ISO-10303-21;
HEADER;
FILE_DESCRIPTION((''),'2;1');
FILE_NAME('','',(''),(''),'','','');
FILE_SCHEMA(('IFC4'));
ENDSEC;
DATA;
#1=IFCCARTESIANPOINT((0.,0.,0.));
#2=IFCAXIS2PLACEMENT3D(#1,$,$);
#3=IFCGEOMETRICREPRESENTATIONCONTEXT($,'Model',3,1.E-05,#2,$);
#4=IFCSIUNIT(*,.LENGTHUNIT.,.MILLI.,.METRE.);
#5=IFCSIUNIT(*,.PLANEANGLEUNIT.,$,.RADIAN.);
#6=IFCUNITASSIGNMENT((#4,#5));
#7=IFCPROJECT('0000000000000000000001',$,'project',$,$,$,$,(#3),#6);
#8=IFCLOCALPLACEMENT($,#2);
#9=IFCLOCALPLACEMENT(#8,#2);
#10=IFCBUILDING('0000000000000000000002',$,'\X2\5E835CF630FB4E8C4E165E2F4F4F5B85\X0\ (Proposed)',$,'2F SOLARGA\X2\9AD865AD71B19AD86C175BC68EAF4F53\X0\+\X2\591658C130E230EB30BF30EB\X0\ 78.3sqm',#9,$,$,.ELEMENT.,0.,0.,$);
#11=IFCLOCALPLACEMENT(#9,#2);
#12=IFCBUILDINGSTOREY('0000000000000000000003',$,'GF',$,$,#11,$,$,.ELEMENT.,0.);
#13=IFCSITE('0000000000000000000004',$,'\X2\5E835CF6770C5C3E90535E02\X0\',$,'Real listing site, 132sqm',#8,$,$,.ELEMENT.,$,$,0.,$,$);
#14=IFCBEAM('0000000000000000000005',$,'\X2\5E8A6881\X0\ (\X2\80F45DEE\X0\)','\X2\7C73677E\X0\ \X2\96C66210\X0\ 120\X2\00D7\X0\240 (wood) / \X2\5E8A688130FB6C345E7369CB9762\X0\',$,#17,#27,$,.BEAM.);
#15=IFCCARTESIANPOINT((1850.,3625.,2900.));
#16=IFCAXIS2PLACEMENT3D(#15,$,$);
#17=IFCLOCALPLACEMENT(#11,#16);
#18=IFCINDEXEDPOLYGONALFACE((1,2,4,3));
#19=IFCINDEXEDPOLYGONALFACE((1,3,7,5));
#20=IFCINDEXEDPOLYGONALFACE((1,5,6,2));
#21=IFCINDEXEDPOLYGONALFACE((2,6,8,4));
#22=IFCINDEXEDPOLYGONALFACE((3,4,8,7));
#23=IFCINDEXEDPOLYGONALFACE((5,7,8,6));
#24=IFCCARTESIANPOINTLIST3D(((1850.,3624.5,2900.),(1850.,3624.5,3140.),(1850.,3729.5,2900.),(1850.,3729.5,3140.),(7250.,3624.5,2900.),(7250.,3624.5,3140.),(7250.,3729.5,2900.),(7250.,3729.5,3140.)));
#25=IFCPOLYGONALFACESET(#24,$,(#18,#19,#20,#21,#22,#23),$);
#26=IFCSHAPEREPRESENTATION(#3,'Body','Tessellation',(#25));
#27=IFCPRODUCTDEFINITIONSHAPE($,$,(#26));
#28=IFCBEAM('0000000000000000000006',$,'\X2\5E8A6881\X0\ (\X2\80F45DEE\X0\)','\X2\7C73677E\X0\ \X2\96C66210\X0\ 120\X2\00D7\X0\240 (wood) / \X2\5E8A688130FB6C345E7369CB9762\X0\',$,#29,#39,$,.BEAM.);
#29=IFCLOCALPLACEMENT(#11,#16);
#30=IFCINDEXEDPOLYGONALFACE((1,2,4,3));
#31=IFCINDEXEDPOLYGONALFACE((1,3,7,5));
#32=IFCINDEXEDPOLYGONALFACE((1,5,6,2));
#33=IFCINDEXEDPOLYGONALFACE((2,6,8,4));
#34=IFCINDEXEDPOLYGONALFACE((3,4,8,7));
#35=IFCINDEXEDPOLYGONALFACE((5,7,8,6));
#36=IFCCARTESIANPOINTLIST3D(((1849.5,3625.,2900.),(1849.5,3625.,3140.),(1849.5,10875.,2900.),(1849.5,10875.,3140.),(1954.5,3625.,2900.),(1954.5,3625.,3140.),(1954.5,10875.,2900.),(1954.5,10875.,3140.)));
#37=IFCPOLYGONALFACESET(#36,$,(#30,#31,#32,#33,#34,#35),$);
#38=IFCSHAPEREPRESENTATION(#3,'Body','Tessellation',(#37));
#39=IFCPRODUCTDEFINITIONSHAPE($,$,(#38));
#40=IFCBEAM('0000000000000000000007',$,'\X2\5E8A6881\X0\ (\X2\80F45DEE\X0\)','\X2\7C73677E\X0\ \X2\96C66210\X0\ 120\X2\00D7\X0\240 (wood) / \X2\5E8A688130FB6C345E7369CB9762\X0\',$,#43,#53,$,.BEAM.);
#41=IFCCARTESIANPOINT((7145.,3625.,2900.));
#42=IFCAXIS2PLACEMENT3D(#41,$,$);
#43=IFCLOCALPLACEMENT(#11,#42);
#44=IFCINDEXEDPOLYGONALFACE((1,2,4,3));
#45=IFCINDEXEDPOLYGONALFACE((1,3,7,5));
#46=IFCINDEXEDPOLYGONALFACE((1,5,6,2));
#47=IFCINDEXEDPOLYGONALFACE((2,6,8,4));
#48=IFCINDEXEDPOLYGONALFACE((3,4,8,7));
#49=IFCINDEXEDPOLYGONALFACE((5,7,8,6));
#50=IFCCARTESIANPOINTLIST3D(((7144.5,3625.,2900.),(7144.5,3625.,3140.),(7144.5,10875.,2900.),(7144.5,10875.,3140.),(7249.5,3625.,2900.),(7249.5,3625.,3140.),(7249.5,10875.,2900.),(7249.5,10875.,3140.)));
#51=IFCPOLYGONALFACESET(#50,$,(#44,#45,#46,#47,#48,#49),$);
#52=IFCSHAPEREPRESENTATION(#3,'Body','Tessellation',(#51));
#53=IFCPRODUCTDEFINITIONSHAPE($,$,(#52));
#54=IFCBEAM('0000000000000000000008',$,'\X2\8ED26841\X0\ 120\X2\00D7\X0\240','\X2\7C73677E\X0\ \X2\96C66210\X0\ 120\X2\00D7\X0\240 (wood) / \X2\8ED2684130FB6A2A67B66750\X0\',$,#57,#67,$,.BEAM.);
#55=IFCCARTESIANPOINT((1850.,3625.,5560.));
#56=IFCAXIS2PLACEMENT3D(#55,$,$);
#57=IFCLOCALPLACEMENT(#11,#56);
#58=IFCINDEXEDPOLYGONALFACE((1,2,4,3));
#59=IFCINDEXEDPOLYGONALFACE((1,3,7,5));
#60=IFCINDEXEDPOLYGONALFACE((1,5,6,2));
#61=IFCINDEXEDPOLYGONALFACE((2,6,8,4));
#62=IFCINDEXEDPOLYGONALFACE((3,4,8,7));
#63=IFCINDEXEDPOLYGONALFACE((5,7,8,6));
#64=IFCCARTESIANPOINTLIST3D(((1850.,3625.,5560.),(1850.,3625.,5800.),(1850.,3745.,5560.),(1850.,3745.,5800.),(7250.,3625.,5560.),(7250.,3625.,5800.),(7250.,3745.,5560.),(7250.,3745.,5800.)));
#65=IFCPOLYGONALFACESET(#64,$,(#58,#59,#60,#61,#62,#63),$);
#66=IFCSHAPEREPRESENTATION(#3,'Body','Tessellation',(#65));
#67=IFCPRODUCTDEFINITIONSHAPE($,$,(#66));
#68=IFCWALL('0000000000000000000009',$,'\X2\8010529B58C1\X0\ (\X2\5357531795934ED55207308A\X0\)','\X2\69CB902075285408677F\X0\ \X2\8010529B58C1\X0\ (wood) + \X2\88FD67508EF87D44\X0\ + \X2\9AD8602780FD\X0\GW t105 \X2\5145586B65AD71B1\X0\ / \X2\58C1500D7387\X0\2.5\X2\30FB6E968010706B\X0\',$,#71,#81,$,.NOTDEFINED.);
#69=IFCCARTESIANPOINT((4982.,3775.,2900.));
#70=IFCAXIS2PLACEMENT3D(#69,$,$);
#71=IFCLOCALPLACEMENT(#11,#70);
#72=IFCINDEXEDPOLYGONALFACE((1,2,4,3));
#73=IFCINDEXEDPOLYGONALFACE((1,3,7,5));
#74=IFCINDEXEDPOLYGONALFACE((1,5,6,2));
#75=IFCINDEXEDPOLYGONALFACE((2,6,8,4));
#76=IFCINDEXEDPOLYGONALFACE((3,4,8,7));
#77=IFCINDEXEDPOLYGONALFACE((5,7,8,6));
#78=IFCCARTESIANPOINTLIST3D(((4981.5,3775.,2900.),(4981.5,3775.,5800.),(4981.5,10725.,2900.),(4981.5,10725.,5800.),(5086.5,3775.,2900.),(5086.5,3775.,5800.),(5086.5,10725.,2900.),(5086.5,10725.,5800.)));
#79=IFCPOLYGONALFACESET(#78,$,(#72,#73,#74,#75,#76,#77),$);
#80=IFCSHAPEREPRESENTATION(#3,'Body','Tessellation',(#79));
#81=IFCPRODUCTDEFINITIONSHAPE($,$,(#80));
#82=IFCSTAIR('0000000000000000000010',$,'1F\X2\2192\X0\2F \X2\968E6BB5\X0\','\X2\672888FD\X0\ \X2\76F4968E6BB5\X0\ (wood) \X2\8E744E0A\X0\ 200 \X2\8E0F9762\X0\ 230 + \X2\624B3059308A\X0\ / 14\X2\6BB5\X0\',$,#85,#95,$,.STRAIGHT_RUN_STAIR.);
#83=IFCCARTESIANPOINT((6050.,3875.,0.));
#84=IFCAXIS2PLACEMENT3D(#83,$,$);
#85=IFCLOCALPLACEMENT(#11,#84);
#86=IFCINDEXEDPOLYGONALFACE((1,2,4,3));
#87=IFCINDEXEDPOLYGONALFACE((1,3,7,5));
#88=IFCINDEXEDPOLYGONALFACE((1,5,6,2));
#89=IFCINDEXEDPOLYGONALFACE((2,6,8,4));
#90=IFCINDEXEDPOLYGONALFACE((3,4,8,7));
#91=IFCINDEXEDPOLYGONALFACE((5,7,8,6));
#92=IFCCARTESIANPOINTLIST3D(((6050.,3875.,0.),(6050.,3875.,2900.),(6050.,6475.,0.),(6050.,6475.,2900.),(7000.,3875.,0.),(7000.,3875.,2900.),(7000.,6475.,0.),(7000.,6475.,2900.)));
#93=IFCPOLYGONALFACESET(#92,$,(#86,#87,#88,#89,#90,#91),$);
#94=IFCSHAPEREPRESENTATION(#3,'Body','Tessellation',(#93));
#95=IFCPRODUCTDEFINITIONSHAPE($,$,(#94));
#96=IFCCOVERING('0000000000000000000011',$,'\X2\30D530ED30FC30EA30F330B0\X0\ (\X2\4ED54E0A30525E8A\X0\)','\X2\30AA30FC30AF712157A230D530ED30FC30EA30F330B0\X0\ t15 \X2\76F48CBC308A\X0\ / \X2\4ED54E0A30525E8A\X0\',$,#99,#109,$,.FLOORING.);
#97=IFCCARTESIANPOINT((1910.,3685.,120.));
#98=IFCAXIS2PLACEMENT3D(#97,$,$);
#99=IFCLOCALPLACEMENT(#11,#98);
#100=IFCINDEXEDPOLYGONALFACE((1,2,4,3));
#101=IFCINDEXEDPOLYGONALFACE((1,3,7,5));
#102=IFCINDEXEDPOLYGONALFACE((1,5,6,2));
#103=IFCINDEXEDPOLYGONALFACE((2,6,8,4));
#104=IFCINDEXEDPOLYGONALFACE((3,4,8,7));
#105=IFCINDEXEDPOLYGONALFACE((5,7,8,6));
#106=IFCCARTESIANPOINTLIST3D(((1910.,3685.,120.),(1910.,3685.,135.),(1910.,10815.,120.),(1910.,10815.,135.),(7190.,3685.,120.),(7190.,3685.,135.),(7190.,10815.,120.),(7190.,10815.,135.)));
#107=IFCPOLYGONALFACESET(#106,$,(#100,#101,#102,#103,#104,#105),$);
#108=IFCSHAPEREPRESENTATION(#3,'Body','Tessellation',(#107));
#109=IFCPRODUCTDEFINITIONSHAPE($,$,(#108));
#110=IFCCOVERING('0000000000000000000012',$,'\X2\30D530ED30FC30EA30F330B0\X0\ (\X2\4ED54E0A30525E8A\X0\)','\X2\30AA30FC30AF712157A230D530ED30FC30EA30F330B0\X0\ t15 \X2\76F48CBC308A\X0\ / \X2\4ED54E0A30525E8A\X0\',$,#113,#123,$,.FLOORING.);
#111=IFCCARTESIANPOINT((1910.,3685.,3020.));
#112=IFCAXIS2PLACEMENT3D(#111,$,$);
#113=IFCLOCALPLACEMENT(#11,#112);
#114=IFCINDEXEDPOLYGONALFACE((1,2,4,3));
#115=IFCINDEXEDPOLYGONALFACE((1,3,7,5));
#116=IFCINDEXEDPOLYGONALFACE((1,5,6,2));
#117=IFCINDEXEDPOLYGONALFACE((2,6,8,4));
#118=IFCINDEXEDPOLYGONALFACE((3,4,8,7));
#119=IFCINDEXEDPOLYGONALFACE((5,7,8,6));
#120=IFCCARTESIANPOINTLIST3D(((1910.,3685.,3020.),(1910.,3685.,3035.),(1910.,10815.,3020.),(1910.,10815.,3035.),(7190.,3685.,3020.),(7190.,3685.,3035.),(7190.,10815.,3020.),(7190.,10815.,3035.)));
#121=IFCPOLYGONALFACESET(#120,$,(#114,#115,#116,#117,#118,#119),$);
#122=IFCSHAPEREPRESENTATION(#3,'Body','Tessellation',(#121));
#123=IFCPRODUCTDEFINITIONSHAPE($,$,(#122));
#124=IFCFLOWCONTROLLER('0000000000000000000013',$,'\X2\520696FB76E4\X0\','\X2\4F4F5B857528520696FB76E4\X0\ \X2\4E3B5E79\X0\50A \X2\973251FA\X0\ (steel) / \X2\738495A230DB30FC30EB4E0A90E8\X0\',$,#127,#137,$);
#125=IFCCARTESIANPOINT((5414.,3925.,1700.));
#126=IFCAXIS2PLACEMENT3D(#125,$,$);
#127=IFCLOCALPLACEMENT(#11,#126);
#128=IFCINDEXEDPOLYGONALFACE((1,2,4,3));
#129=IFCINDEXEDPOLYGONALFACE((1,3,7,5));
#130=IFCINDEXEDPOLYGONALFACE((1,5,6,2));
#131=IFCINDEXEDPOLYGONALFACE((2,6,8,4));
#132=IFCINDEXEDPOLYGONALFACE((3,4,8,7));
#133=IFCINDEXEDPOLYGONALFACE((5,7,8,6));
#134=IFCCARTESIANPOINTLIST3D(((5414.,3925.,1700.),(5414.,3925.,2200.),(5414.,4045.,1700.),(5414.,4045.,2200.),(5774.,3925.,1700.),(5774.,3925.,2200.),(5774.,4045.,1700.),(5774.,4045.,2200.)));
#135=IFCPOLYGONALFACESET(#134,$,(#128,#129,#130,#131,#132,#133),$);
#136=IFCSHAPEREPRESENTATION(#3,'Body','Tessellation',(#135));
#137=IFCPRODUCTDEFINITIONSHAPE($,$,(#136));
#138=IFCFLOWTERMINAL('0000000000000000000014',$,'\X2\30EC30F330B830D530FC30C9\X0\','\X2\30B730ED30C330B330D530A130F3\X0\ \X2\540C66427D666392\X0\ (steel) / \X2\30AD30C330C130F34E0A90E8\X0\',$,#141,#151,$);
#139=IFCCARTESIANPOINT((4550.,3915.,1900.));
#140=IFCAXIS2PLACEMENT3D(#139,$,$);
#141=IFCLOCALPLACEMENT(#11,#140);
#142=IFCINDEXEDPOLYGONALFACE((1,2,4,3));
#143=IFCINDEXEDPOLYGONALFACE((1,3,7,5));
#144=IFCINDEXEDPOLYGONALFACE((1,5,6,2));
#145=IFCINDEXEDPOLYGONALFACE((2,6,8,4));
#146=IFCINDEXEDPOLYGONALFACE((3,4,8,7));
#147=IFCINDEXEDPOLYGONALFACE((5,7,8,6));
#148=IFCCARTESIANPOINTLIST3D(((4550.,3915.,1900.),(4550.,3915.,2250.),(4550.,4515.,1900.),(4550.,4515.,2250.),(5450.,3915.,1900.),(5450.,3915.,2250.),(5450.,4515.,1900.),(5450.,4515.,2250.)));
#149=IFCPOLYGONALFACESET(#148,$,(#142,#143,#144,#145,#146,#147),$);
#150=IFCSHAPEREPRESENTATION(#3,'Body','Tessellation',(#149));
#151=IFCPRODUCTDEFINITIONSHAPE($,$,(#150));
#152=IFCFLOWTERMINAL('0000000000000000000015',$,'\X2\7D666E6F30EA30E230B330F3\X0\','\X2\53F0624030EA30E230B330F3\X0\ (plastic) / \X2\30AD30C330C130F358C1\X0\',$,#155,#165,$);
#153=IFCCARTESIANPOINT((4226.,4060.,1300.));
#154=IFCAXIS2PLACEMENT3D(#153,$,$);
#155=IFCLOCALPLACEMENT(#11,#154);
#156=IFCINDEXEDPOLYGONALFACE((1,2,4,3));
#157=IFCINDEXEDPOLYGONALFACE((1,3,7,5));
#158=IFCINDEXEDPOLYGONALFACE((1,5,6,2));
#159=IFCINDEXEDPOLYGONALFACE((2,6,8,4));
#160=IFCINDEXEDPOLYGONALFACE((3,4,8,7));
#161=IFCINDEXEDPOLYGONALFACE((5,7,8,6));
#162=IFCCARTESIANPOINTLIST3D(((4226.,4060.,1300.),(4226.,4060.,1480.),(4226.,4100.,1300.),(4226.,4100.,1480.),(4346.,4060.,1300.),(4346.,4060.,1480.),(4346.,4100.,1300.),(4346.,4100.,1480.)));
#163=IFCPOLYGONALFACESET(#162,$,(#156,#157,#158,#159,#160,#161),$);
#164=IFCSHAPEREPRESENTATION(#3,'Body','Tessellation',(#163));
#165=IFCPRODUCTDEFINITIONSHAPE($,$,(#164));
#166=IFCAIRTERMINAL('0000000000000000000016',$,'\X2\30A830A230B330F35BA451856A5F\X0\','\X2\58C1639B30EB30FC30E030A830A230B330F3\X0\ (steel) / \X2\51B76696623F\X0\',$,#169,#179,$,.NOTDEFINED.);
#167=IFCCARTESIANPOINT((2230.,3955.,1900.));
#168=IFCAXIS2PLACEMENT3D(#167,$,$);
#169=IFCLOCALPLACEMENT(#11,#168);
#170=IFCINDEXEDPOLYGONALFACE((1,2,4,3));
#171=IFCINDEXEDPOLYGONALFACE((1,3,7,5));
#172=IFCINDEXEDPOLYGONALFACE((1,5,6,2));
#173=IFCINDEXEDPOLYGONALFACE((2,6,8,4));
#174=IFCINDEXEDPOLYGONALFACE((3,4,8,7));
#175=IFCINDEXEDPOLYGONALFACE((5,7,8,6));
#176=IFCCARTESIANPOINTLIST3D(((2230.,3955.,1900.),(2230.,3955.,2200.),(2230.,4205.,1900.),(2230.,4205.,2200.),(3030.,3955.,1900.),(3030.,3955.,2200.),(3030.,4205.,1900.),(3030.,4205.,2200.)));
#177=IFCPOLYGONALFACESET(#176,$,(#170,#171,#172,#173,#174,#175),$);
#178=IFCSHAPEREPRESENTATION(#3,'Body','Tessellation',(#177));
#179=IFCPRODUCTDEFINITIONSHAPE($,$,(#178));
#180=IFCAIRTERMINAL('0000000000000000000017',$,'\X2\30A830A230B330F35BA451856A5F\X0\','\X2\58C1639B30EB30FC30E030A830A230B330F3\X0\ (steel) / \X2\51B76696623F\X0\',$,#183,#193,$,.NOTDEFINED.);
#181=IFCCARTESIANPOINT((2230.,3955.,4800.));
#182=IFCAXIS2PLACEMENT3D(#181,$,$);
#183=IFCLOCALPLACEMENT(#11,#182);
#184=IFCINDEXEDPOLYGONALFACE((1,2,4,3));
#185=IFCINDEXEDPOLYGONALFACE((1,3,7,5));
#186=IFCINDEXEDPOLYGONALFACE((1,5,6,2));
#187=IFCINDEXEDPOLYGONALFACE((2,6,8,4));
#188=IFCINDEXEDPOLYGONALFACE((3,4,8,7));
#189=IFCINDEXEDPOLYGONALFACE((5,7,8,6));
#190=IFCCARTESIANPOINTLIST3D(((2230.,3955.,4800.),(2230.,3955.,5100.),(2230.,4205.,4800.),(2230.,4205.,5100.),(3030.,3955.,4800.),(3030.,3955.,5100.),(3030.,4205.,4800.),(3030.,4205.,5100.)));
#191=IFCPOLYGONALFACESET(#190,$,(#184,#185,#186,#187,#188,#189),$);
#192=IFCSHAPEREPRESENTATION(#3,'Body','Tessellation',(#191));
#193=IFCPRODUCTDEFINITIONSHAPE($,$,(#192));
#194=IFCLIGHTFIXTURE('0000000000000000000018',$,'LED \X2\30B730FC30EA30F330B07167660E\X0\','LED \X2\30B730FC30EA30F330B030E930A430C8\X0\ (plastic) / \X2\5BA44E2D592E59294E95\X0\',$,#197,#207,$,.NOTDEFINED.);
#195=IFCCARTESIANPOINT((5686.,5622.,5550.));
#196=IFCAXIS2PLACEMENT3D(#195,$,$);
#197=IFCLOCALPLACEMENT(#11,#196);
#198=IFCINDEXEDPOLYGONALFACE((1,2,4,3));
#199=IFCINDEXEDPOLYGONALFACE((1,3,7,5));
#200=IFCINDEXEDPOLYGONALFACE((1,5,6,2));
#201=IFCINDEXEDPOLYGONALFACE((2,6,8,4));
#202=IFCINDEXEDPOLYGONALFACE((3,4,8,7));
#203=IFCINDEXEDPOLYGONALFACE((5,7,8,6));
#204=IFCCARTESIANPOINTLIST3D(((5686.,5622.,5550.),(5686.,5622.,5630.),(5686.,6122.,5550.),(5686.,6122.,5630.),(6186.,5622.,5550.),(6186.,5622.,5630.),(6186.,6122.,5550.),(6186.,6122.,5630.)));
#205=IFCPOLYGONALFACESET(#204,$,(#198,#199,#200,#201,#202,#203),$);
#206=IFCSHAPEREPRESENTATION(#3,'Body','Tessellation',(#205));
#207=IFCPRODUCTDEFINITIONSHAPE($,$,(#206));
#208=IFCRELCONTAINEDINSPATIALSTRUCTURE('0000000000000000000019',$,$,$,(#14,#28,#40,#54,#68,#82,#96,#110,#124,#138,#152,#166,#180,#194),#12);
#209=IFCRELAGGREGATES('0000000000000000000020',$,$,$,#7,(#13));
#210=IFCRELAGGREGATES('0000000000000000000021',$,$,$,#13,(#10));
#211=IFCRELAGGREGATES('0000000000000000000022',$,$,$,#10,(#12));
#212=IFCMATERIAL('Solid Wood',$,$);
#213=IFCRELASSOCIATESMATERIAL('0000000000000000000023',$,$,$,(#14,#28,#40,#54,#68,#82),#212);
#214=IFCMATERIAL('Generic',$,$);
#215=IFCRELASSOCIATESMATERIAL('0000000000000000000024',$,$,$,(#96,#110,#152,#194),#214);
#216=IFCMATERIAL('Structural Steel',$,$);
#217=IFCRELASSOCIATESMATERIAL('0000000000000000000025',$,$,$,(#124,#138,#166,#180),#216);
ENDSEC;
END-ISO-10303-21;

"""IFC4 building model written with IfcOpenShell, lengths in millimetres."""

from ifc_helpers import new_model, si_unit, frame, frame_2d, origin, place, context, project, spatial, rectangle, extrude, material, element, save


model = new_model("IFC4")

# Units and contexts
model_context = context("Model", 3, precision=1e-05, world=origin())
ifc_project = project(units=[si_unit("LENGTHUNIT", "METRE", prefix="MILLI"), si_unit("PLANEANGLEUNIT", "RADIAN")], contexts=[model_context])

# Site, building, storey
site_placement = place(None, origin())
site = spatial("IfcSite", under=ifc_project, at=site_placement, Name="広島県尾道市", ObjectType="Real listing site, 132sqm", CompositionType="ELEMENT", RefElevation=0.0)
building_placement = place(site_placement, origin())
building = spatial("IfcBuilding", under=site, at=building_placement, Name="広島・二世帯住宅 (Proposed)", ObjectType="2F SOLARGA高断熱高気密躯体+外壁モルタル 78.3sqm", CompositionType="ELEMENT", ElevationOfRefHeight=0.0, ElevationOfTerrain=0.0)
storey_placement = place(building_placement, origin())
storey = spatial("IfcBuildingStorey", under=building, at=storey_placement, Name="GF", CompositionType="ELEMENT", Elevation=0.0)

# Shared definitions
ifc_material_1 = material(Name="Solid Wood")

# Beams
beam_1_placement = place(storey_placement, frame((1850.0, 3625.0, 2900.0)))
element("IfcBeam", 1, at=beam_1_placement, inside=storey, material=ifc_material_1, Name="床梁 (胴差)", Description="米松 集成 120×240 (wood) / 床梁・水平構面", PredefinedType="BEAM", context=model_context, shape_type="SweptSolid", body=[
    extrude(rectangle(XDim=5400.0, YDim=105.0, at=frame_2d((2700.0, 52.0))), frame((1850.0, 3625.0, 2900.0)), (0.0, 0.0, 1.0), 240.0),
])
beam_2_placement = place(storey_placement, frame((1850.0, 3625.0, 2900.0)))
element("IfcBeam", 2, at=beam_2_placement, inside=storey, material=ifc_material_1, Name="床梁 (胴差)", Description="米松 集成 120×240 (wood) / 床梁・水平構面", PredefinedType="BEAM", context=model_context, shape_type="SweptSolid", body=[
    extrude(rectangle(XDim=105.0, YDim=7250.0, at=frame_2d((52.0, 3625.0))), frame((1850.0, 3625.0, 2900.0)), (0.0, 0.0, 1.0), 240.0),
])
beam_3_placement = place(storey_placement, frame((7145.0, 3625.0, 2900.0)))
element("IfcBeam", 3, at=beam_3_placement, inside=storey, material=ifc_material_1, Name="床梁 (胴差)", Description="米松 集成 120×240 (wood) / 床梁・水平構面", PredefinedType="BEAM", context=model_context, shape_type="SweptSolid", body=[
    extrude(rectangle(XDim=105.0, YDim=7250.0, at=frame_2d((52.0, 3625.0))), frame((7145.0, 3625.0, 2900.0)), (0.0, 0.0, 1.0), 240.0),
])
beam_4_placement = place(storey_placement, frame((1850.0, 3625.0, 5560.0)))
element("IfcBeam", 4, at=beam_4_placement, inside=storey, material=ifc_material_1, Name="軒桁 120×240", Description="米松 集成 120×240 (wood) / 軒桁・横架材", PredefinedType="BEAM", context=model_context, shape_type="SweptSolid", body=[
    extrude(rectangle(XDim=5400.0, YDim=120.0, at=frame_2d((2700.0, 60.0))), frame((1850.0, 3625.0, 5560.0)), (0.0, 0.0, 1.0), 240.0),
])

# Wall
wall_1_placement = place(storey_placement, frame((4982.0, 3775.0, 2900.0)))
element("IfcWall", 5, at=wall_1_placement, inside=storey, material=ifc_material_1, Name="耐力壁 (南北間仕切り)", Description="構造用合板 耐力壁 (wood) + 製材軸組 + 高性能GW t105 充填断熱 / 壁倍率2.5・準耐火", PredefinedType="NOTDEFINED", context=model_context, shape_type="SweptSolid", body=[
    extrude(rectangle(XDim=105.0, YDim=6950.0, at=frame_2d((52.0, 3475.0))), frame((4982.0, 3775.0, 2900.0)), (0.0, 0.0, 1.0), 2900.0),
])

# Stair
stair_placement = place(storey_placement, frame((6050.0, 3875.0, 0.0)))
element("IfcStair", 6, at=stair_placement, inside=storey, material=ifc_material_1, Name="1F→2F 階段", Description="木製 直階段 (wood) 蹴上 200 踏面 230 + 手すり / 14段", PredefinedType="STRAIGHT_RUN_STAIR", context=model_context, shape_type="SweptSolid", body=[
    extrude(rectangle(XDim=950.0, YDim=2600.0, at=frame_2d((475.0, 1300.0))), frame((6050.0, 3875.0, 0.0)), (0.0, 0.0, 1.0), 2900.0),
])

# Coverings
ifc_material_2 = material(Name="Generic")
covering_1_placement = place(storey_placement, frame((1910.0, 3685.0, 120.0)))
element("IfcCovering", 7, at=covering_1_placement, inside=storey, material=ifc_material_2, Name="フローリング (仕上げ床)", Description="オーク無垢フローリング t15 直貼り / 仕上げ床", PredefinedType="FLOORING", context=model_context, shape_type="SweptSolid", body=[
    extrude(rectangle(XDim=5280.0, YDim=7130.0, at=frame_2d((2640.0, 3565.0))), frame((1910.0, 3685.0, 120.0)), (0.0, 0.0, 1.0), 15.0),
])
covering_2_placement = place(storey_placement, frame((1910.0, 3685.0, 3020.0)))
element("IfcCovering", 8, at=covering_2_placement, inside=storey, material=ifc_material_2, Name="フローリング (仕上げ床)", Description="オーク無垢フローリング t15 直貼り / 仕上げ床", PredefinedType="FLOORING", context=model_context, shape_type="SweptSolid", body=[
    extrude(rectangle(XDim=5280.0, YDim=7130.0, at=frame_2d((2640.0, 3565.0))), frame((1910.0, 3685.0, 3020.0)), (0.0, 0.0, 1.0), 15.0),
])

# Flow controller
ifc_material_3 = material(Name="Structural Steel")
flow_controller_placement = place(storey_placement, frame((5414.0, 3925.0, 1700.0)))
element("IfcFlowController", 9, at=flow_controller_placement, inside=storey, material=ifc_material_3, Name="分電盤", Description="住宅用分電盤 主幹50A 露出 (steel) / 玄関ホール上部", context=model_context, shape_type="SweptSolid", body=[
    extrude(rectangle(XDim=360.0, YDim=120.0, at=frame_2d((180.0, 60.0))), frame((5414.0, 3925.0, 1700.0)), (0.0, 0.0, 1.0), 500.0),
])

# Flow terminals
flow_terminal_1_placement = place(storey_placement, frame((4550.0, 3915.0, 1900.0)))
element("IfcFlowTerminal", 10, at=flow_terminal_1_placement, inside=storey, material=ifc_material_3, Name="レンジフード", Description="シロッコファン 同時給排 (steel) / キッチン上部", context=model_context, shape_type="SweptSolid", body=[
    extrude(rectangle(XDim=900.0, YDim=600.0, at=frame_2d((450.0, 300.0))), frame((4550.0, 3915.0, 1900.0)), (0.0, 0.0, 1.0), 350.0),
])
flow_terminal_2_placement = place(storey_placement, frame((4226.0, 4060.0, 1300.0)))
element("IfcFlowTerminal", 11, at=flow_terminal_2_placement, inside=storey, material=ifc_material_2, Name="給湯リモコン", Description="台所リモコン (plastic) / キッチン壁", context=model_context, shape_type="SweptSolid", body=[
    extrude(rectangle(XDim=120.0, YDim=40.0, at=frame_2d((60.0, 20.0))), frame((4226.0, 4060.0, 1300.0)), (0.0, 0.0, 1.0), 180.0),
])

# Air terminals
air_terminal_1_placement = place(storey_placement, frame((2230.0, 3955.0, 1900.0)))
element("IfcAirTerminal", 12, at=air_terminal_1_placement, inside=storey, material=ifc_material_3, Name="エアコン室内機", Description="壁掛ルームエアコン (steel) / 冷暖房", PredefinedType="NOTDEFINED", context=model_context, shape_type="SweptSolid", body=[
    extrude(rectangle(XDim=800.0, YDim=250.0, at=frame_2d((400.0, 125.0))), frame((2230.0, 3955.0, 1900.0)), (0.0, 0.0, 1.0), 300.0),
])
air_terminal_2_placement = place(storey_placement, frame((2230.0, 3955.0, 4800.0)))
element("IfcAirTerminal", 13, at=air_terminal_2_placement, inside=storey, material=ifc_material_3, Name="エアコン室内機", Description="壁掛ルームエアコン (steel) / 冷暖房", PredefinedType="NOTDEFINED", context=model_context, shape_type="SweptSolid", body=[
    extrude(rectangle(XDim=800.0, YDim=250.0, at=frame_2d((400.0, 125.0))), frame((2230.0, 3955.0, 4800.0)), (0.0, 0.0, 1.0), 300.0),
])

# Light fixture
light_fixture_placement = place(storey_placement, frame((5686.0, 5622.0, 5550.0)))
element("IfcLightFixture", 14, at=light_fixture_placement, inside=storey, material=ifc_material_2, Name="LED シーリング照明", Description="LED シーリングライト (plastic) / 室中央天井", PredefinedType="NOTDEFINED", context=model_context, shape_type="SweptSolid", body=[
    extrude(rectangle(XDim=500.0, YDim=500.0, at=frame_2d((250.0, 250.0))), frame((5686.0, 5622.0, 5550.0)), (0.0, 0.0, 1.0), 80.0),
])

save(model, "model.ifc")
